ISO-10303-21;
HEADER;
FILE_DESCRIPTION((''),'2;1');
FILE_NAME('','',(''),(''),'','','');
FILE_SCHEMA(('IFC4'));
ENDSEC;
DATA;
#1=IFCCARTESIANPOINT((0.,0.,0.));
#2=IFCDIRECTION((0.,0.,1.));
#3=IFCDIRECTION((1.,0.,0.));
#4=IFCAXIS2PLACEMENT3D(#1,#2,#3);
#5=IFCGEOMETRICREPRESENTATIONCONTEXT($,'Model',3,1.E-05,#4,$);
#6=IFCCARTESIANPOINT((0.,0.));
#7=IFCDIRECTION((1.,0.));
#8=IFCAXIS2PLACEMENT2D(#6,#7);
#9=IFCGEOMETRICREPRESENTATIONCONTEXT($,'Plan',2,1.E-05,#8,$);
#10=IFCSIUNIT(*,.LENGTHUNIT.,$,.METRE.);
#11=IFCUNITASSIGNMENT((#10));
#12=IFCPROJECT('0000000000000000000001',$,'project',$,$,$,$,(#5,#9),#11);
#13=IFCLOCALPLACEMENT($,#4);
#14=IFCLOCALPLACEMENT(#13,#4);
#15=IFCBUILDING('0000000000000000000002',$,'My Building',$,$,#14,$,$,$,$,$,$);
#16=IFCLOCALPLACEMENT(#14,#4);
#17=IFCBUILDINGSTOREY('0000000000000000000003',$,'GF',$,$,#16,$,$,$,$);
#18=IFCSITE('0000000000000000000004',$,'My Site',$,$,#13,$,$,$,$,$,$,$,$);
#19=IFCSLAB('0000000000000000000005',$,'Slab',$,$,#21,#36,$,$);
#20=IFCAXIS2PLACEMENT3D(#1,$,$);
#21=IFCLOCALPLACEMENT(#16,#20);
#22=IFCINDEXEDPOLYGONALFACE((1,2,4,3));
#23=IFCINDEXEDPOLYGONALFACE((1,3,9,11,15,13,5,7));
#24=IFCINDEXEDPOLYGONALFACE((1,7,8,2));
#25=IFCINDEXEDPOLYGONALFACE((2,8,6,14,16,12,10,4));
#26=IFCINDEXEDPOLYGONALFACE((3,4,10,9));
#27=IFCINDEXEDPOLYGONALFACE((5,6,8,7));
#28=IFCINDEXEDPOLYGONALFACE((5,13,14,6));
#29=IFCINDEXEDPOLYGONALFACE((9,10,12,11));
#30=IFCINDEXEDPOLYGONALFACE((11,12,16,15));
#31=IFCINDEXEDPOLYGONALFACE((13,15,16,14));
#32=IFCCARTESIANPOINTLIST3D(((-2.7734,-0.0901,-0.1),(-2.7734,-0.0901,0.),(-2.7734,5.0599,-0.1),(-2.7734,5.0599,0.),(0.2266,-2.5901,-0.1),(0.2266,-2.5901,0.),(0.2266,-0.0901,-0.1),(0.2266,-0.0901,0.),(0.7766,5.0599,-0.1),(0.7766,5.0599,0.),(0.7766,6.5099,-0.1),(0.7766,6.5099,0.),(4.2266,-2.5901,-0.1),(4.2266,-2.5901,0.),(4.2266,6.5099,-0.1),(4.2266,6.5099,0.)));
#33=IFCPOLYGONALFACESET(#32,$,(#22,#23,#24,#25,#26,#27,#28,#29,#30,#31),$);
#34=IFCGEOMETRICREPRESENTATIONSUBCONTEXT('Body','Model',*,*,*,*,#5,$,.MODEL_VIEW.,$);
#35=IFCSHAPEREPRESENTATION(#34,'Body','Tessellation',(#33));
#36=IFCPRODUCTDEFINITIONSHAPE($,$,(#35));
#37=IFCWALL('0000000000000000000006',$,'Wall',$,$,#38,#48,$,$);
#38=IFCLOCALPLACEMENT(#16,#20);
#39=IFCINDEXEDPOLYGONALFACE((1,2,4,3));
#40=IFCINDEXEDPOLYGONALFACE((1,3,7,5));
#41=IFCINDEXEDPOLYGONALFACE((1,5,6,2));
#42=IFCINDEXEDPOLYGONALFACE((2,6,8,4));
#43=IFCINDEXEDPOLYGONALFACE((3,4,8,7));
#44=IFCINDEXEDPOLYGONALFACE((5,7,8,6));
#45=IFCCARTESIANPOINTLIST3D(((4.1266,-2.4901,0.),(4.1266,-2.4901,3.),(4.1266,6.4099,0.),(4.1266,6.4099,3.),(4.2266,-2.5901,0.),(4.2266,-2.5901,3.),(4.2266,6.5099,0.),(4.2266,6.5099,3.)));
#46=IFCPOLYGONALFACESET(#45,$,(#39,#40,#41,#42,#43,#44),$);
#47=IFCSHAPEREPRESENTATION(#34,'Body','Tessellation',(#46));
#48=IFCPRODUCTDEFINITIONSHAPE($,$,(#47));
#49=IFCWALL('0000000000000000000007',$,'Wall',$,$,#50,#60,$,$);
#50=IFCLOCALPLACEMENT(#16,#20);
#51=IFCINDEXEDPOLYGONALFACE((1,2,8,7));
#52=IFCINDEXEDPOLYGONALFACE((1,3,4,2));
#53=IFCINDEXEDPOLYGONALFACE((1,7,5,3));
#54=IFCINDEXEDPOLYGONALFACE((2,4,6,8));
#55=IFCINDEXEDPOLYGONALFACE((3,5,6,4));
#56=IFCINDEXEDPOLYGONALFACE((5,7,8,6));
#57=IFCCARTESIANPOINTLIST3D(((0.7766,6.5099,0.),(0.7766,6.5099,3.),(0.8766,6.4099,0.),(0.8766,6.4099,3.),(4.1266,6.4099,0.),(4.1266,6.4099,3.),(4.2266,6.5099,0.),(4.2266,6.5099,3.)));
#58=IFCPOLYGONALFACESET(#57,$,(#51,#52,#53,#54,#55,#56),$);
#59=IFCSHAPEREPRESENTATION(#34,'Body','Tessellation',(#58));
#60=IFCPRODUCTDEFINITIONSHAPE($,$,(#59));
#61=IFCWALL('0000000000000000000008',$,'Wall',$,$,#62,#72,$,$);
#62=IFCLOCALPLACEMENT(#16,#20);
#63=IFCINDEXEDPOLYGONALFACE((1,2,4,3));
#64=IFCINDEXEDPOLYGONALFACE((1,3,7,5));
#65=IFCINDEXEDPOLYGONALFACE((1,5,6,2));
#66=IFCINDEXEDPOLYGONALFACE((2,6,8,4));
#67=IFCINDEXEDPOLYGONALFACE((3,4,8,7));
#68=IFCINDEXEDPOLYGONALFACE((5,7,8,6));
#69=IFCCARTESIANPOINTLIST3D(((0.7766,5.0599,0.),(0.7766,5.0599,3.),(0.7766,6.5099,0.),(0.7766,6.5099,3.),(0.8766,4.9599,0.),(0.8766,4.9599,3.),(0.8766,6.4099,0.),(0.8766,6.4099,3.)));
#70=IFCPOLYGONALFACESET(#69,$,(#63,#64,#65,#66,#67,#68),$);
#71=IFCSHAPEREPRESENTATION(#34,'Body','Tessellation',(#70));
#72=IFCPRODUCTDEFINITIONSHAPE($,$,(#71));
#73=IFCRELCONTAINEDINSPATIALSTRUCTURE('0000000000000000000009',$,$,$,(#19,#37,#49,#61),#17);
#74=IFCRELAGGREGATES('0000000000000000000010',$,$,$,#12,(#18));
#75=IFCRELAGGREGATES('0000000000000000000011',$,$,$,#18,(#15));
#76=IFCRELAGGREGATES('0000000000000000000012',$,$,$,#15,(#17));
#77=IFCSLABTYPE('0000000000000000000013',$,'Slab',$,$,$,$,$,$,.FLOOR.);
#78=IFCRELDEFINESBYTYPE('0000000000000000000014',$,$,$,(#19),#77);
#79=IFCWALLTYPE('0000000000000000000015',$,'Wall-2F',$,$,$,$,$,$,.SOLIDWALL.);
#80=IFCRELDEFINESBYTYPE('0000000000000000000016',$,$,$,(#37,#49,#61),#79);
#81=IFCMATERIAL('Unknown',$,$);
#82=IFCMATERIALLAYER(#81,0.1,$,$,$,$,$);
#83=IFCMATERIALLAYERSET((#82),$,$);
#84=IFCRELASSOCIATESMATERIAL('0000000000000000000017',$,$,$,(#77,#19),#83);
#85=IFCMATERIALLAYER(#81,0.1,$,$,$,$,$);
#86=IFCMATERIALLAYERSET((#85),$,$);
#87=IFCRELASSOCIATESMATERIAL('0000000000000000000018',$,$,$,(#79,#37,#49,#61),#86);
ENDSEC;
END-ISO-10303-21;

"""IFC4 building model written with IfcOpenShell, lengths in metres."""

from ifc_helpers import new_model, si_unit, frame, origin_with_axes, origin_2d_with_axis, place, context, subcontext, project, spatial, line, indexed_curve, outline, extrude, material, layer, layer_set, layer_usage, type_object, element, save


model = new_model("IFC4")

# Units and contexts
model_context = context("Model", 3, precision=1e-05, world=origin_with_axes())
plan_context = context("Plan", 2, precision=1e-05, world=origin_2d_with_axis())
body_context_1 = subcontext(model_context, "Body", "Model", "MODEL_VIEW")
ifc_project = project(units=[si_unit("LENGTHUNIT", "METRE")], contexts=[model_context, plan_context])

# Site, building, storey
site_placement = place(None, origin_with_axes())
site = spatial("IfcSite", under=ifc_project, at=site_placement, Name="My Site")
building_placement = place(site_placement, origin_with_axes())
building = spatial("IfcBuilding", under=site, at=building_placement, Name="My Building")
storey_placement = place(building_placement, origin_with_axes())
storey = spatial("IfcBuildingStorey", under=building, at=storey_placement, Name="GF")

# Slab
ifc_material = material(Name="Unknown")
ifc_layer_1 = layer(ifc_material, 0.1)
ifc_layer_set_1 = layer_set([ifc_layer_1])
ifc_layer_usage_1 = layer_usage(ifc_layer_set_1, "AXIS3", "POSITIVE", -0.1)
slab_type = type_object("IfcSlabType", Name="Slab", PredefinedType="FLOOR", material=ifc_layer_set_1)
slab_placement = place(storey_placement, frame((4.2266, -2.5901, 0.0), z_axis=(0.0, 0.0, 1.0), x_axis=(1.0, 0.0, 0.0)))
element("IfcSlab", 1, at=slab_placement, inside=storey, type_object=slab_type, material=ifc_layer_usage_1, Name="Slab", context=body_context_1, shape_type="SweptSolid", body=[
    extrude(outline(indexed_curve([(0.0, 0.0), (0.0, 9.1), (-3.45, 9.1), (-3.45, 7.65), (-7.0, 7.65), (-7.0, 2.5), (-4.0, 2.5), (-4.0, 0.0), (0.0, 0.0)])), frame((0.0, 0.0, -0.1), z_axis=(0.0, 0.0, 1.0), x_axis=(1.0, 0.0, 0.0)), (0.0, 0.0, 1.0), 0.1),
])

# Shared definitions
ifc_layer_2 = layer(ifc_material, 0.1)
ifc_layer_set_2 = layer_set([ifc_layer_2])
wall_type = type_object("IfcWallType", Name="Wall-2F", PredefinedType="SOLIDWALL", material=ifc_layer_set_2)

# Walls
ifc_layer_usage_2 = layer_usage(ifc_layer_set_2, "AXIS2", "POSITIVE", 0.0)
wall_1_placement = place(storey_placement, frame((4.2266, -2.5901, 0.0), z_axis=(0.0, 0.0, 1.0), x_axis=(0.0, 1.0, 0.0)))
element("IfcWall", 2, at=wall_1_placement, inside=storey, type_object=wall_type, material=ifc_layer_usage_2, Name="Wall", context=body_context_1, shape_type="SweptSolid", body=[
    extrude(outline(indexed_curve([(0.0, 0.0), (0.1, 0.1), (9.0, 0.1), (9.1, 0.0)], segments=[line(1, 2, 3, 4, 1)])), origin_with_axes(), (0.0, 0.0, 1.0), 3.0),
])
ifc_layer_usage_3 = layer_usage(ifc_layer_set_2, "AXIS2", "POSITIVE", 0.0)
wall_2_placement = place(storey_placement, frame((4.2266, 6.5099, 0.0), z_axis=(0.0, 0.0, 1.0), x_axis=(-1.0, 0.0, 0.0)))
element("IfcWall", 3, at=wall_2_placement, inside=storey, type_object=wall_type, material=ifc_layer_usage_3, Name="Wall", context=body_context_1, shape_type="SweptSolid", body=[
    extrude(outline(indexed_curve([(0.0, 0.0), (0.1, 0.1), (3.35, 0.1), (3.45, 0.0)], segments=[line(1, 2, 3, 4, 1)])), origin_with_axes(), (0.0, 0.0, 1.0), 3.0),
])
ifc_layer_usage_4 = layer_usage(ifc_layer_set_2, "AXIS2", "POSITIVE", 0.0)
wall_3_placement = place(storey_placement, frame((0.7766, 6.5099, 0.0), z_axis=(0.0, 0.0, 1.0), x_axis=(0.0, -1.0, 0.0)))
element("IfcWall", 4, at=wall_3_placement, inside=storey, type_object=wall_type, material=ifc_layer_usage_4, Name="Wall", context=body_context_1, shape_type="SweptSolid", body=[
    extrude(outline(indexed_curve([(0.0, 0.0), (0.1, 0.1), (1.55, 0.1), (1.45, 0.0)], segments=[line(1, 2, 3, 4, 1)])), origin_with_axes(), (0.0, 0.0, 1.0), 3.0),
])

save(model, "model.ifc")
